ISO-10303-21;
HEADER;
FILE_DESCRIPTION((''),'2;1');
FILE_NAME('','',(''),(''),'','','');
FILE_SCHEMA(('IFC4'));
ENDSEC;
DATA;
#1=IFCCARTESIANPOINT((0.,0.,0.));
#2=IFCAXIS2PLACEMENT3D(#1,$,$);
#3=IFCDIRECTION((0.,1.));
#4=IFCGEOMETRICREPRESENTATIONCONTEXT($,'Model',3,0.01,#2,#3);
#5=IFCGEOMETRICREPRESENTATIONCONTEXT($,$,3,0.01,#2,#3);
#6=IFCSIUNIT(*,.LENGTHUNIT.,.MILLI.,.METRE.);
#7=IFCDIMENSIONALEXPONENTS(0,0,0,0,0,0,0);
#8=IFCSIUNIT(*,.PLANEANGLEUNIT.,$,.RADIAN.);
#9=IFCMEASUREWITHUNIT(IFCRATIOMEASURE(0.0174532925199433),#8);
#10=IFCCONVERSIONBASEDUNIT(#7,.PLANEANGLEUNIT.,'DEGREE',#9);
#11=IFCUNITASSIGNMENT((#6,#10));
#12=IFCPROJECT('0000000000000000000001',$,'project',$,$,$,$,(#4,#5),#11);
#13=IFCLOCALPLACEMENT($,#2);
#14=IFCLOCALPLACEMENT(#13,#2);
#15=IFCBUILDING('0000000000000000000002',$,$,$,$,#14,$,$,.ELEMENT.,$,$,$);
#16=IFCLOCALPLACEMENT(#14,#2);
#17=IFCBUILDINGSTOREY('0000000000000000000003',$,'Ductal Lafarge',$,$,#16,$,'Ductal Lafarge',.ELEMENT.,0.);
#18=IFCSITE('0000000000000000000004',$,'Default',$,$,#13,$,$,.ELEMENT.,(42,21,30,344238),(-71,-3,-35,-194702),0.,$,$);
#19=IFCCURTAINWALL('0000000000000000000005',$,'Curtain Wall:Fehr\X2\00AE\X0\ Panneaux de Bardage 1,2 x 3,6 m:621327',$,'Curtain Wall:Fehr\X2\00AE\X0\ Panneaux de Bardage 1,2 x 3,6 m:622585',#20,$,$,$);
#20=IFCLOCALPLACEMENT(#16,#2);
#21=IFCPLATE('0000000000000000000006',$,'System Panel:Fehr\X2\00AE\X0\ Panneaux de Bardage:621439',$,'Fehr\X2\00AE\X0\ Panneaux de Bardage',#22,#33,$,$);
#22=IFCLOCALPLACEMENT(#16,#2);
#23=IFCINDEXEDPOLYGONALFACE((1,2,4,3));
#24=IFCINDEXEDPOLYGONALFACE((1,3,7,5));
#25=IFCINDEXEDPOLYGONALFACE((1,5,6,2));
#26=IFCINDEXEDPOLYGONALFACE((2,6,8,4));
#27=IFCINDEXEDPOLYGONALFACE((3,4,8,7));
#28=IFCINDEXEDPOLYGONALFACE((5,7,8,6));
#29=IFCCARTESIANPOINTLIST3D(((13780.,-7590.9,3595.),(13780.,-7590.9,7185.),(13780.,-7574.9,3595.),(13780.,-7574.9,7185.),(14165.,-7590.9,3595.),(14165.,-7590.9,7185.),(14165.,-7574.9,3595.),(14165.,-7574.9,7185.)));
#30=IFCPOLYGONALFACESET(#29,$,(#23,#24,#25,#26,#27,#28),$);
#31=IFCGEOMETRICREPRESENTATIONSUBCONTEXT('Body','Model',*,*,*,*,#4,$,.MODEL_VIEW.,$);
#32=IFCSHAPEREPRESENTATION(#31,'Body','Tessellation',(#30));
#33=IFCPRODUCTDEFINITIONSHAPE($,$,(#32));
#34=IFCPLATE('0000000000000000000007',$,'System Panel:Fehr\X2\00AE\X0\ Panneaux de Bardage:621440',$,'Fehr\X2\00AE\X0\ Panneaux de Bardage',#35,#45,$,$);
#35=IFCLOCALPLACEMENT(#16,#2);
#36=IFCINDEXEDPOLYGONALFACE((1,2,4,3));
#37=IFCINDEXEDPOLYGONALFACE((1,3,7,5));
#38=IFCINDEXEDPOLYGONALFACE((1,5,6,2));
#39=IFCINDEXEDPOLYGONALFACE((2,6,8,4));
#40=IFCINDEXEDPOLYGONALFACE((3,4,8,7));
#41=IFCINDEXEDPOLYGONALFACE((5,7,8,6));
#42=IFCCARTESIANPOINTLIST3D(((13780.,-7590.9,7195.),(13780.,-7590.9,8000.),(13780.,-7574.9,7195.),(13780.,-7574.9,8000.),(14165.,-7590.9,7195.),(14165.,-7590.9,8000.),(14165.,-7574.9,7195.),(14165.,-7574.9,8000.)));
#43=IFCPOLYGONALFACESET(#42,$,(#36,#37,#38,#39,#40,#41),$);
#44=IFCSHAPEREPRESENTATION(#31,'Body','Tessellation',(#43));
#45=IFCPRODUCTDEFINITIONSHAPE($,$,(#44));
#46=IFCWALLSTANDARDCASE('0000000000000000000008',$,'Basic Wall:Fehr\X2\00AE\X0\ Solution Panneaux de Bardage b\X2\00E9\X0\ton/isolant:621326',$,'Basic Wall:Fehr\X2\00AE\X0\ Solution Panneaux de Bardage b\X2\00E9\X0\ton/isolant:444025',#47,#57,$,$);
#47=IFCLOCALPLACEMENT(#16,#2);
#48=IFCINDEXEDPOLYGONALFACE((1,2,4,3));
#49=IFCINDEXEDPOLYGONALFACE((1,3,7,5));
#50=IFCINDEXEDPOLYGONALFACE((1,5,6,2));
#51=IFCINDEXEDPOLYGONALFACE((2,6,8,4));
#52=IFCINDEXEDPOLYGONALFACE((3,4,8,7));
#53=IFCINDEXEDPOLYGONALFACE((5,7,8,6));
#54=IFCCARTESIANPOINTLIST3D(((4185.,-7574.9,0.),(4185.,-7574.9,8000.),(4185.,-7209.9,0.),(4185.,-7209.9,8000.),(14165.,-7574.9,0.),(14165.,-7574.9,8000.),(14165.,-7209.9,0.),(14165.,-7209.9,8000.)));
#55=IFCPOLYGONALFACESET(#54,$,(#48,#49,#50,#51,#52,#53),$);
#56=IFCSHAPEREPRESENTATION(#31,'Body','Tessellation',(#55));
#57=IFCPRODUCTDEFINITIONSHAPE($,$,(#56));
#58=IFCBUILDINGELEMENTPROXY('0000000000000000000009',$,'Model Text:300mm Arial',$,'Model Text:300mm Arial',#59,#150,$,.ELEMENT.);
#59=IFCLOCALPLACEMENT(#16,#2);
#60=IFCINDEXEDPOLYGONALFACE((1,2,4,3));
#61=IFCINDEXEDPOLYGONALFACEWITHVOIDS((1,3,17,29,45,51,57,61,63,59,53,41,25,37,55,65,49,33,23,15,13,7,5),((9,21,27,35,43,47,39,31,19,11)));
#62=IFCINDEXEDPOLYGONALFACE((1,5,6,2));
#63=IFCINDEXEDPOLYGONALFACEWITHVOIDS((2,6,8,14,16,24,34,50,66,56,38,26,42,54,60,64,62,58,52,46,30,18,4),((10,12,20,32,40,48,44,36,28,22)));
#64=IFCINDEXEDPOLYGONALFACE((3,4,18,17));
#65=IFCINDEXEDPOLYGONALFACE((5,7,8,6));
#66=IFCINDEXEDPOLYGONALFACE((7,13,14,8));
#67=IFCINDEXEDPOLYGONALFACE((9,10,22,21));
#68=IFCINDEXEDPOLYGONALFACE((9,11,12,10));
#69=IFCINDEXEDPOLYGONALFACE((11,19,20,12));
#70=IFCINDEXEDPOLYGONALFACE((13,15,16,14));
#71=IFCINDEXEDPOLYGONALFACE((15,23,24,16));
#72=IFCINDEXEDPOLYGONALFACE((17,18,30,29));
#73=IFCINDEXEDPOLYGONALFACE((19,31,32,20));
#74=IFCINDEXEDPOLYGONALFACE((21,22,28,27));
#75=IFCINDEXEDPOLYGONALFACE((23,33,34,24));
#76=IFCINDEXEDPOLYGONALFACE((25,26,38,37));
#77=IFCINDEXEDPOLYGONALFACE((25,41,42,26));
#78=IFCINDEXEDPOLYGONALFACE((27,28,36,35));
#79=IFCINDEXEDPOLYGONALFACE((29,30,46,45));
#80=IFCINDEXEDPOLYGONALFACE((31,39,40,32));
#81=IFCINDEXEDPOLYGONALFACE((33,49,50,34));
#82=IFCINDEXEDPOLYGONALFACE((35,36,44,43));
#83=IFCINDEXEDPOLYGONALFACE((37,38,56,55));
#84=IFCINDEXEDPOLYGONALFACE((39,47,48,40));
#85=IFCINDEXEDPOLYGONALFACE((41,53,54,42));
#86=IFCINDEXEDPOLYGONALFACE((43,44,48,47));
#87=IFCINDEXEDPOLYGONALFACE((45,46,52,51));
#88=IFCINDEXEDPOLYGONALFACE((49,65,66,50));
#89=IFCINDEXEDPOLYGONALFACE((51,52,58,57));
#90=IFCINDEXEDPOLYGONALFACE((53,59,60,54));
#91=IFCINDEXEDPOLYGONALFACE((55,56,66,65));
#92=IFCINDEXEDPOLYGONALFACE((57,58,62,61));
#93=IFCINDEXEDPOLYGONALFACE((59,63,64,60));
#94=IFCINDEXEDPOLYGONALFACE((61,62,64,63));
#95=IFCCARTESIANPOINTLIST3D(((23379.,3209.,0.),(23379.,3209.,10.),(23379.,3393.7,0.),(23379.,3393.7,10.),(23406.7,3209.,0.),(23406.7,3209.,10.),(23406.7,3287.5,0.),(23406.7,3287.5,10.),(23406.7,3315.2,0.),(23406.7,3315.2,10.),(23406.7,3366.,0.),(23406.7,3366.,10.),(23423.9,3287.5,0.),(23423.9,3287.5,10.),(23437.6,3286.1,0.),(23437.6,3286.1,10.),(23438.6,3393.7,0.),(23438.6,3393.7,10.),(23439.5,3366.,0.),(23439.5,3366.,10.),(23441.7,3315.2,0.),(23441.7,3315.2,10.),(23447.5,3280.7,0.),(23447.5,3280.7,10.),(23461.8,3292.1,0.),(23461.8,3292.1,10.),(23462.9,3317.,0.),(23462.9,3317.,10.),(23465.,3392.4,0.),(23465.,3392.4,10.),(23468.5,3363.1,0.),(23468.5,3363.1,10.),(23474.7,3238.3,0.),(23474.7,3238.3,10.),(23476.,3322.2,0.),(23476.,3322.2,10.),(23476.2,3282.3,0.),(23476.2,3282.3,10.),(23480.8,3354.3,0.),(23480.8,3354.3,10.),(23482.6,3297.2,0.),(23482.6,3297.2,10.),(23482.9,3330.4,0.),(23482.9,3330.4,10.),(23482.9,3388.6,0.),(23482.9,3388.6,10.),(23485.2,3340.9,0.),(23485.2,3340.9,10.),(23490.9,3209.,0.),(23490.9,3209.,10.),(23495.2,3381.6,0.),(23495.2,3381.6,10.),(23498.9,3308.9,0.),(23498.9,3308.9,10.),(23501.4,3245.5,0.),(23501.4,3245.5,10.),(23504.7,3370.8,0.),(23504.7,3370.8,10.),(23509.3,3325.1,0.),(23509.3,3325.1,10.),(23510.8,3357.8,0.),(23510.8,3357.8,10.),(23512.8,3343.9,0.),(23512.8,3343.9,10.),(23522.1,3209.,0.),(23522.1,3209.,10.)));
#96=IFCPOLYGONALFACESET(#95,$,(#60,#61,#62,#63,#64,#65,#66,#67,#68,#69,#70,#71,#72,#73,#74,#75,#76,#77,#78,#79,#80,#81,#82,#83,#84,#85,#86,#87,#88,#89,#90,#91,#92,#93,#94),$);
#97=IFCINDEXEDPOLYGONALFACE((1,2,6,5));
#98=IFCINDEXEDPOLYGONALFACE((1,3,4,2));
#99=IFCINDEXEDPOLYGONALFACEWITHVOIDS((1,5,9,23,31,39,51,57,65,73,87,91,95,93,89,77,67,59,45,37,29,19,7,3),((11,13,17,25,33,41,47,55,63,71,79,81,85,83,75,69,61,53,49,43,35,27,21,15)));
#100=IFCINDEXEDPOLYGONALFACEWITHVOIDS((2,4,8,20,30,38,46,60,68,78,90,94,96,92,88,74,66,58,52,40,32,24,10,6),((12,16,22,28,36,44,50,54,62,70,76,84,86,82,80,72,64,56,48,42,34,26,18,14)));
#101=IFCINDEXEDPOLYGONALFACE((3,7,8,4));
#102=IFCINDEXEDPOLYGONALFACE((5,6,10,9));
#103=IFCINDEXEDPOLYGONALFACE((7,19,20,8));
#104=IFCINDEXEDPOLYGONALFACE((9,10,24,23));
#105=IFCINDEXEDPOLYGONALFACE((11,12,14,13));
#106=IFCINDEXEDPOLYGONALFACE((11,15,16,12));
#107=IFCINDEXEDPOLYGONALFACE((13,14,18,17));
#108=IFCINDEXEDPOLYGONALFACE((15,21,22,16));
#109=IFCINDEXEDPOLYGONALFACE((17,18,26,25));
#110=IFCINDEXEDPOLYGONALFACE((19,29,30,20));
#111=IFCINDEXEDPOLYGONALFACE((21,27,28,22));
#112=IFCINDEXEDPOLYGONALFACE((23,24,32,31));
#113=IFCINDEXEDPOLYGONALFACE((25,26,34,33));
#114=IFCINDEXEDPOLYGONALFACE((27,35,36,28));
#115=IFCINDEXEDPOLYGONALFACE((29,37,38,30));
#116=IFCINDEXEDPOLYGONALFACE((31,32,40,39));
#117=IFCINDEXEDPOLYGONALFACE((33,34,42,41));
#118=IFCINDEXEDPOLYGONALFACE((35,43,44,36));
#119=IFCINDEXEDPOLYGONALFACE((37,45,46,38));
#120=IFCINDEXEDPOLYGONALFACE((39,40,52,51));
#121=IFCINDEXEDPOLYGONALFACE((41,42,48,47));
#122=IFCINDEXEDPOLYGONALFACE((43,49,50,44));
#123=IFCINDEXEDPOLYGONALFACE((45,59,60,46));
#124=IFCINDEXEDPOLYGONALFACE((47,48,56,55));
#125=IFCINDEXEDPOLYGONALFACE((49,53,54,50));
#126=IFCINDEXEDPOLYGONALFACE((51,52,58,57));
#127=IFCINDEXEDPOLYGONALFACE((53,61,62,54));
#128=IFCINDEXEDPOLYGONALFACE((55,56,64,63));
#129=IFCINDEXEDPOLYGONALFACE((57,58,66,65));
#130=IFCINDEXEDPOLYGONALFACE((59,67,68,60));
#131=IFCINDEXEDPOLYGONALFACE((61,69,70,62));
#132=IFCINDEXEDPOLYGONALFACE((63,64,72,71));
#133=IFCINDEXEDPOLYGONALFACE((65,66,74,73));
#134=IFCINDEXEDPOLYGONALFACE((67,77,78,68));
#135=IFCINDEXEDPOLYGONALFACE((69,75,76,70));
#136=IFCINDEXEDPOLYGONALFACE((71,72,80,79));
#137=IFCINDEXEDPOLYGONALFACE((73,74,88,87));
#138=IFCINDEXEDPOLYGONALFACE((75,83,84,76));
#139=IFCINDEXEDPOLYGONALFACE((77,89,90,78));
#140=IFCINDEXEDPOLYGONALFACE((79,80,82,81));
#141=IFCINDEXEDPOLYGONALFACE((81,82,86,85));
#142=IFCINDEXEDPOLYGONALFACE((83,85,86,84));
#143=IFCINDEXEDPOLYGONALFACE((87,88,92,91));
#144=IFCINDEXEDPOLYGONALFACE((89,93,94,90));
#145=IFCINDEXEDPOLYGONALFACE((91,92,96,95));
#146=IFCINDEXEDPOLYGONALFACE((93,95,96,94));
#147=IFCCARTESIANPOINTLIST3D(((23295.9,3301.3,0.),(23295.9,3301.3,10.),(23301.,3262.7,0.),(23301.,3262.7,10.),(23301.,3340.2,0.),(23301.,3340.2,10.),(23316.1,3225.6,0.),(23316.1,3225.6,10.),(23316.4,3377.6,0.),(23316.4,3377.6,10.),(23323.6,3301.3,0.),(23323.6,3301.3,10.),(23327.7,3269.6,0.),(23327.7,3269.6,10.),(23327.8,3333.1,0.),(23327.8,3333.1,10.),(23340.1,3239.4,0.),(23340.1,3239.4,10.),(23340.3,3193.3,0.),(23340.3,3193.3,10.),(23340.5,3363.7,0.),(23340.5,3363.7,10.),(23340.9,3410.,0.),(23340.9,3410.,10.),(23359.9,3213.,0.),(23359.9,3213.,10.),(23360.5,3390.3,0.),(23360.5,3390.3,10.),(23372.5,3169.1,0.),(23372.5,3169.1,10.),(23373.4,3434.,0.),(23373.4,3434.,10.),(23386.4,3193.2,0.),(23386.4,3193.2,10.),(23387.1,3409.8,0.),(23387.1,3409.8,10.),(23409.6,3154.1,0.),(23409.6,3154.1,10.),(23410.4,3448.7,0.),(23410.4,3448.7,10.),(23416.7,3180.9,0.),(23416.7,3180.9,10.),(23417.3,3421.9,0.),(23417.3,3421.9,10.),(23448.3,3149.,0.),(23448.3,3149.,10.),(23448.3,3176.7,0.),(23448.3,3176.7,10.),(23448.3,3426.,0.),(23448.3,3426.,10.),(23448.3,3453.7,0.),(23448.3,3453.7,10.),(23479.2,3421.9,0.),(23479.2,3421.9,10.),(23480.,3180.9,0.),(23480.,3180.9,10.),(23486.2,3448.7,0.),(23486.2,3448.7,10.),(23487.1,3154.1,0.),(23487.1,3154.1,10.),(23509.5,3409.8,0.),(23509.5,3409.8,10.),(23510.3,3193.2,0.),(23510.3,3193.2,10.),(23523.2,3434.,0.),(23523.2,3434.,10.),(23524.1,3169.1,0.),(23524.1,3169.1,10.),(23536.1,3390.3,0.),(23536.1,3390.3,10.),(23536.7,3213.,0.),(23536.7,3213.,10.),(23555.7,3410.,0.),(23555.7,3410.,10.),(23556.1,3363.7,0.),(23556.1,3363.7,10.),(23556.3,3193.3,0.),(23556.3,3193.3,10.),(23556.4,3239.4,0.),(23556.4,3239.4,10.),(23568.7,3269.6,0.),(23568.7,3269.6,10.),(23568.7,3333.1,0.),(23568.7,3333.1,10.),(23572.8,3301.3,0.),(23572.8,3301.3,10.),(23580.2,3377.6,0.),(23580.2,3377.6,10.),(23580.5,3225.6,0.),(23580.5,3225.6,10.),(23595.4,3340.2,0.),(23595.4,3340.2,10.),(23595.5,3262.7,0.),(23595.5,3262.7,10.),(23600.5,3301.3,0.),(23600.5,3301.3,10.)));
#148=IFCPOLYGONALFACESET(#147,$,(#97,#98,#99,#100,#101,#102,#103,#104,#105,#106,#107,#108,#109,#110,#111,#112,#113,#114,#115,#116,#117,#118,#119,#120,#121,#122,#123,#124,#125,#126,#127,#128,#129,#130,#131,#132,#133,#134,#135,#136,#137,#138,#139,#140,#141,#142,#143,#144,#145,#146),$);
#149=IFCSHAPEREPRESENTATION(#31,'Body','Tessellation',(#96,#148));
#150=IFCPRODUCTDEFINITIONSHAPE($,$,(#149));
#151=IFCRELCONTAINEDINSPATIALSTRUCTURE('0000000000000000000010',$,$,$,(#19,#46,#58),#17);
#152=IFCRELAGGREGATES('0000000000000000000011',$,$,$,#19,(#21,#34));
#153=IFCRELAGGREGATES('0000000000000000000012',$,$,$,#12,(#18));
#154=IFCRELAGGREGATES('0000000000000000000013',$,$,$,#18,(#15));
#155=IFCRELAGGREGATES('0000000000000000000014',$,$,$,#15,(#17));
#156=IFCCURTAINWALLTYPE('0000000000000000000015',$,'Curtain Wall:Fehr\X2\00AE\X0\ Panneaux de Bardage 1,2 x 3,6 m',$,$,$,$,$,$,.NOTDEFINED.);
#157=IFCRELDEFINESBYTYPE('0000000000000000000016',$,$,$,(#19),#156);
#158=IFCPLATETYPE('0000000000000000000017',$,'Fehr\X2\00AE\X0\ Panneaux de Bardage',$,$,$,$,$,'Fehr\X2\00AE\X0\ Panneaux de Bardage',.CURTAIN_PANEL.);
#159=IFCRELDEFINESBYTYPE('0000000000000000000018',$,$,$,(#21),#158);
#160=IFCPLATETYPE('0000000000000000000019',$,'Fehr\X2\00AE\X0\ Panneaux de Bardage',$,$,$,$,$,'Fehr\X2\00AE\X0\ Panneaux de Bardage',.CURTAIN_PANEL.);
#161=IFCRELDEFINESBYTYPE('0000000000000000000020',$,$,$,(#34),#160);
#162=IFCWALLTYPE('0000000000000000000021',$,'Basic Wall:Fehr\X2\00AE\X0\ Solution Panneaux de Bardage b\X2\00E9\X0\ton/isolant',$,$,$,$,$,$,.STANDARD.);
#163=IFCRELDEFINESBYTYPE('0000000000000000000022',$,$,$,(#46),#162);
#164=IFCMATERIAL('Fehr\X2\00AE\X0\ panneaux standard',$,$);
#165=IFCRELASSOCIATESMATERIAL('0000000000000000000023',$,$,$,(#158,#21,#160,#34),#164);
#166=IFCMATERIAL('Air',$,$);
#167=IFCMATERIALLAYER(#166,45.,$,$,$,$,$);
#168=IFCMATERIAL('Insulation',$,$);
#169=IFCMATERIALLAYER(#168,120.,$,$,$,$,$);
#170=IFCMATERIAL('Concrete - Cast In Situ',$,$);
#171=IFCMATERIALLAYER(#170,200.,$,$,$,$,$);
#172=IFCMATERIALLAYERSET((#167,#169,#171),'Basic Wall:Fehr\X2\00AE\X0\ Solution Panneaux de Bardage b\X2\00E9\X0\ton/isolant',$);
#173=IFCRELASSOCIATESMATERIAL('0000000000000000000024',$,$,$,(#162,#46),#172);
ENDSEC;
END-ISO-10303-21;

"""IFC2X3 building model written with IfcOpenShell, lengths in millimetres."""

from ifc_helpers import new_model, entity, si_unit, converted_unit, direction, frame, frame_2d, origin, origin_2d_with_axis, place, context, subcontext, project, spatial, polyline, rectangle, outline, extrude, source, transform, mapped, material, layer, layer_set, layer_usage, type_object, type_shapes, element, aggregate, save


model = new_model("IFC2X3")

# Units and contexts
model_context = context("Model", 3, precision=0.01, world=origin(), true_north=direction((0.0, 1.0)))
context_of_model = context(None, 3, precision=0.01, world=origin(), true_north=direction((0.0, 1.0)))
body_context = subcontext(model_context, "Body", "Model", "MODEL_VIEW")
ifc_project = project(units=[si_unit("LENGTHUNIT", "METRE", prefix="MILLI"), converted_unit("PLANEANGLEUNIT", "DEGREE", entity("IfcRatioMeasure", 0.0174532925199433), si_unit("PLANEANGLEUNIT", "RADIAN"), dimensions=[0, 0, 0, 0, 0, 0, 0])], contexts=[model_context, context_of_model])

# Site, building, storey
site_placement = place(None, origin())
site = spatial("IfcSite", under=ifc_project, at=site_placement, Name="Default", CompositionType="ELEMENT", RefLatitude=(42, 21, 30, 344238), RefLongitude=(-71, -3, -35, -194702), RefElevation=0.0)
building_placement = place(site_placement, origin())
building = spatial("IfcBuilding", under=site, at=building_placement, CompositionType="ELEMENT")
storey_placement = place(building_placement, origin())
storey = spatial("IfcBuildingStorey", under=building, at=storey_placement, Name="Ductal Lafarge", LongName="Ductal Lafarge", CompositionType="ELEMENT", Elevation=0.0)

# Curtain wall
curtain_wall_type_1 = type_object("IfcCurtainWallType", Name="Curtain Wall:Fehr® Panneaux de Bardage 1,2 x 3,6 m", PredefinedType="NOTDEFINED")
curtain_wall_1_placement = place(storey_placement, origin())
curtain_wall_1 = element("IfcCurtainWall", 1, at=curtain_wall_1_placement, inside=storey, type_object=curtain_wall_type_1, Name="Curtain Wall:Fehr® Panneaux de Bardage 1,2 x 3,6 m:621327", ObjectType="Curtain Wall:Fehr® Panneaux de Bardage 1,2 x 3,6 m:622585")

# Plates
ifc_material_1 = material(Name="Fehr® panneaux standard")
plate_type_1 = type_object("IfcPlateType", Name="Fehr® Panneaux de Bardage", ElementType="Fehr® Panneaux de Bardage", PredefinedType="CURTAIN_PANEL", material=ifc_material_1)
shared_shape_1 = source(origin(), body_context, "Body", "SweptSolid", [
    extrude(rectangle(XDim=16.0, YDim=385.0, at=origin_2d_with_axis()), frame((0.0, 0.0, 0.0), z_axis=(0.0, 0.0, 1.0), x_axis=(0.0, 1.0, 0.0)), (0.0, 0.0, 1.0), 3590.0),
])
type_shapes(plate_type_1, [shared_shape_1])
plate_1_placement = place(curtain_wall_1_placement, frame((13972.5, -7582.9, 3595.0)))
plate_1 = element("IfcPlate", 2, at=plate_1_placement, type_object=plate_type_1, material=ifc_material_1, Name="System Panel:Fehr® Panneaux de Bardage:621439", ObjectType="Fehr® Panneaux de Bardage", context=body_context, shape_type="MappedRepresentation", body=[
    mapped(shared_shape_1, transform((0.0, 0.0, 0.0), scale=1.0)),
])
plate_type_2 = type_object("IfcPlateType", Name="Fehr® Panneaux de Bardage", ElementType="Fehr® Panneaux de Bardage", PredefinedType="CURTAIN_PANEL", material=ifc_material_1)
shared_shape_2 = source(origin(), body_context, "Body", "SweptSolid", [
    extrude(rectangle(XDim=16.0, YDim=385.0, at=origin_2d_with_axis()), frame((0.0, 0.0, 0.0), z_axis=(0.0, 0.0, 1.0), x_axis=(0.0, 1.0, 0.0)), (0.0, 0.0, 1.0), 805.0),
])
type_shapes(plate_type_2, [shared_shape_2])
plate_2_placement = place(curtain_wall_1_placement, frame((13972.5, -7582.9, 7195.0)))
plate_2 = element("IfcPlate", 3, at=plate_2_placement, type_object=plate_type_2, material=ifc_material_1, Name="System Panel:Fehr® Panneaux de Bardage:621440", ObjectType="Fehr® Panneaux de Bardage", context=body_context, shape_type="MappedRepresentation", body=[
    mapped(shared_shape_2, transform((0.0, 0.0, 0.0), scale=1.0)),
])
aggregate(curtain_wall_1, [plate_1, plate_2])

# Wall
ifc_material_2 = material(Name="Air")
ifc_layer_1 = layer(ifc_material_2, 45.0)
ifc_material_3 = material(Name="Insulation")
ifc_layer_2 = layer(ifc_material_3, 120.0)
ifc_material_4 = material(Name="Concrete - Cast In Situ")
ifc_layer_3 = layer(ifc_material_4, 200.0)
ifc_layer_set = layer_set([ifc_layer_1, ifc_layer_2, ifc_layer_3], Name="Basic Wall:Fehr® Solution Panneaux de Bardage béton/isolant")
ifc_layer_usage = layer_usage(ifc_layer_set, "AXIS2", "NEGATIVE", 182.5)
wall_type = type_object("IfcWallType", Name="Basic Wall:Fehr® Solution Panneaux de Bardage béton/isolant", PredefinedType="STANDARD", material=ifc_layer_set)
wall_placement = place(storey_placement, frame((14165.0, -7392.4, 0.0), z_axis=(0.0, 0.0, 1.0), x_axis=(-1.0, 0.0, 0.0)))
element("IfcWallStandardCase", 4, at=wall_placement, inside=storey, type_object=wall_type, material=ifc_layer_usage, Name="Basic Wall:Fehr® Solution Panneaux de Bardage béton/isolant:621326", ObjectType="Basic Wall:Fehr® Solution Panneaux de Bardage béton/isolant:444025", context=body_context, shape_type="SweptSolid", body=[
    extrude(rectangle(XDim=9980.0, YDim=365.0, at=frame_2d((4990.0, 0.0), x_axis=(-1.0, 0.0))), origin(), (0.0, 0.0, 1.0), 8000.0),
])

# Building element proxy
proxy_1_placement = place(storey_placement, frame((23295.9, 3149.0, 0.0)))
element("IfcBuildingElementProxy", 5, at=proxy_1_placement, inside=storey, Name="Model Text:300mm Arial", ObjectType="Model Text:300mm Arial", CompositionType="ELEMENT", context=body_context, shape_type="SweptSolid", body=[
    extrude(outline(polyline([(-86.6, -94.9), (-58.9, -94.9), (-58.9, -16.4), (-41.7, -16.4), (-28.0, -17.8), (-18.1, -23.2), (9.1, -65.6), (25.3, -94.9), (56.5, -94.9), (35.8, -58.4), (10.6, -21.6), (-3.8, -11.8), (17.0, -6.7), (33.3, 5.0), (43.8, 21.2), (47.3, 40.0), (45.2, 53.9), (39.1, 66.9), (29.6, 77.7), (17.3, 84.7), (-0.6, 88.5), (-26.9, 89.8), (-86.6, 89.8), (-86.6, -94.9)]), holes=[polyline([(-58.9, 11.3), (-58.9, 62.1), (-26.1, 62.1), (2.9, 59.2), (15.2, 50.4), (19.6, 37.0), (17.3, 26.5), (10.4, 18.3), (-2.7, 13.1), (-23.8, 11.3), (-58.9, 11.3)])]), frame((169.7, 154.9, 0.0)), (0.0, 0.0, 1.0), 10.0),
    extrude(outline(polyline([(-19.6, -150.9), (18.6, -150.9), (57.1, -141.0), (92.5, -121.5), (121.0, -92.5), (141.0, -57.4), (151.1, -19.4), (151.1, 19.5), (140.9, 58.3), (121.0, 93.4), (92.2, 121.5), (57.4, 141.2), (19.6, 151.2), (-19.4, 151.2), (-58.1, 141.0), (-93.2, 121.2), (-121.3, 92.3), (-141.0, 57.5), (-150.9, 19.8), (-150.9, -19.4), (-140.6, -58.5), (-120.5, -93.8), (-91.4, -121.7), (-56.6, -141.1), (-19.6, -150.9)]), holes=[polyline([(-16.1, -123.4), (-46.2, -115.4), (-74.7, -99.6), (-98.5, -76.7), (-114.9, -47.8), (-123.4, -15.8), (-123.5, 16.3), (-115.3, 47.1), (-99.2, 75.5), (-76.2, 99.1), (-47.5, 115.3), (-15.8, 123.7), (16.1, 123.7), (46.9, 115.6), (75.4, 99.4), (99.0, 76.3), (115.3, 47.7), (123.7, 16.0), (123.7, -15.9), (115.4, -46.9), (98.9, -75.6), (75.6, -99.3), (46.7, -115.3), (15.2, -123.4), (-16.1, -123.4)])]), frame((152.4, 152.5, 0.0), z_axis=(0.0, 0.0, 1.0), x_axis=(-0.991656, -0.128915, 0.0)), (0.0, 0.0, 1.0), 10.0),
])

save(model, "model.ifc")
